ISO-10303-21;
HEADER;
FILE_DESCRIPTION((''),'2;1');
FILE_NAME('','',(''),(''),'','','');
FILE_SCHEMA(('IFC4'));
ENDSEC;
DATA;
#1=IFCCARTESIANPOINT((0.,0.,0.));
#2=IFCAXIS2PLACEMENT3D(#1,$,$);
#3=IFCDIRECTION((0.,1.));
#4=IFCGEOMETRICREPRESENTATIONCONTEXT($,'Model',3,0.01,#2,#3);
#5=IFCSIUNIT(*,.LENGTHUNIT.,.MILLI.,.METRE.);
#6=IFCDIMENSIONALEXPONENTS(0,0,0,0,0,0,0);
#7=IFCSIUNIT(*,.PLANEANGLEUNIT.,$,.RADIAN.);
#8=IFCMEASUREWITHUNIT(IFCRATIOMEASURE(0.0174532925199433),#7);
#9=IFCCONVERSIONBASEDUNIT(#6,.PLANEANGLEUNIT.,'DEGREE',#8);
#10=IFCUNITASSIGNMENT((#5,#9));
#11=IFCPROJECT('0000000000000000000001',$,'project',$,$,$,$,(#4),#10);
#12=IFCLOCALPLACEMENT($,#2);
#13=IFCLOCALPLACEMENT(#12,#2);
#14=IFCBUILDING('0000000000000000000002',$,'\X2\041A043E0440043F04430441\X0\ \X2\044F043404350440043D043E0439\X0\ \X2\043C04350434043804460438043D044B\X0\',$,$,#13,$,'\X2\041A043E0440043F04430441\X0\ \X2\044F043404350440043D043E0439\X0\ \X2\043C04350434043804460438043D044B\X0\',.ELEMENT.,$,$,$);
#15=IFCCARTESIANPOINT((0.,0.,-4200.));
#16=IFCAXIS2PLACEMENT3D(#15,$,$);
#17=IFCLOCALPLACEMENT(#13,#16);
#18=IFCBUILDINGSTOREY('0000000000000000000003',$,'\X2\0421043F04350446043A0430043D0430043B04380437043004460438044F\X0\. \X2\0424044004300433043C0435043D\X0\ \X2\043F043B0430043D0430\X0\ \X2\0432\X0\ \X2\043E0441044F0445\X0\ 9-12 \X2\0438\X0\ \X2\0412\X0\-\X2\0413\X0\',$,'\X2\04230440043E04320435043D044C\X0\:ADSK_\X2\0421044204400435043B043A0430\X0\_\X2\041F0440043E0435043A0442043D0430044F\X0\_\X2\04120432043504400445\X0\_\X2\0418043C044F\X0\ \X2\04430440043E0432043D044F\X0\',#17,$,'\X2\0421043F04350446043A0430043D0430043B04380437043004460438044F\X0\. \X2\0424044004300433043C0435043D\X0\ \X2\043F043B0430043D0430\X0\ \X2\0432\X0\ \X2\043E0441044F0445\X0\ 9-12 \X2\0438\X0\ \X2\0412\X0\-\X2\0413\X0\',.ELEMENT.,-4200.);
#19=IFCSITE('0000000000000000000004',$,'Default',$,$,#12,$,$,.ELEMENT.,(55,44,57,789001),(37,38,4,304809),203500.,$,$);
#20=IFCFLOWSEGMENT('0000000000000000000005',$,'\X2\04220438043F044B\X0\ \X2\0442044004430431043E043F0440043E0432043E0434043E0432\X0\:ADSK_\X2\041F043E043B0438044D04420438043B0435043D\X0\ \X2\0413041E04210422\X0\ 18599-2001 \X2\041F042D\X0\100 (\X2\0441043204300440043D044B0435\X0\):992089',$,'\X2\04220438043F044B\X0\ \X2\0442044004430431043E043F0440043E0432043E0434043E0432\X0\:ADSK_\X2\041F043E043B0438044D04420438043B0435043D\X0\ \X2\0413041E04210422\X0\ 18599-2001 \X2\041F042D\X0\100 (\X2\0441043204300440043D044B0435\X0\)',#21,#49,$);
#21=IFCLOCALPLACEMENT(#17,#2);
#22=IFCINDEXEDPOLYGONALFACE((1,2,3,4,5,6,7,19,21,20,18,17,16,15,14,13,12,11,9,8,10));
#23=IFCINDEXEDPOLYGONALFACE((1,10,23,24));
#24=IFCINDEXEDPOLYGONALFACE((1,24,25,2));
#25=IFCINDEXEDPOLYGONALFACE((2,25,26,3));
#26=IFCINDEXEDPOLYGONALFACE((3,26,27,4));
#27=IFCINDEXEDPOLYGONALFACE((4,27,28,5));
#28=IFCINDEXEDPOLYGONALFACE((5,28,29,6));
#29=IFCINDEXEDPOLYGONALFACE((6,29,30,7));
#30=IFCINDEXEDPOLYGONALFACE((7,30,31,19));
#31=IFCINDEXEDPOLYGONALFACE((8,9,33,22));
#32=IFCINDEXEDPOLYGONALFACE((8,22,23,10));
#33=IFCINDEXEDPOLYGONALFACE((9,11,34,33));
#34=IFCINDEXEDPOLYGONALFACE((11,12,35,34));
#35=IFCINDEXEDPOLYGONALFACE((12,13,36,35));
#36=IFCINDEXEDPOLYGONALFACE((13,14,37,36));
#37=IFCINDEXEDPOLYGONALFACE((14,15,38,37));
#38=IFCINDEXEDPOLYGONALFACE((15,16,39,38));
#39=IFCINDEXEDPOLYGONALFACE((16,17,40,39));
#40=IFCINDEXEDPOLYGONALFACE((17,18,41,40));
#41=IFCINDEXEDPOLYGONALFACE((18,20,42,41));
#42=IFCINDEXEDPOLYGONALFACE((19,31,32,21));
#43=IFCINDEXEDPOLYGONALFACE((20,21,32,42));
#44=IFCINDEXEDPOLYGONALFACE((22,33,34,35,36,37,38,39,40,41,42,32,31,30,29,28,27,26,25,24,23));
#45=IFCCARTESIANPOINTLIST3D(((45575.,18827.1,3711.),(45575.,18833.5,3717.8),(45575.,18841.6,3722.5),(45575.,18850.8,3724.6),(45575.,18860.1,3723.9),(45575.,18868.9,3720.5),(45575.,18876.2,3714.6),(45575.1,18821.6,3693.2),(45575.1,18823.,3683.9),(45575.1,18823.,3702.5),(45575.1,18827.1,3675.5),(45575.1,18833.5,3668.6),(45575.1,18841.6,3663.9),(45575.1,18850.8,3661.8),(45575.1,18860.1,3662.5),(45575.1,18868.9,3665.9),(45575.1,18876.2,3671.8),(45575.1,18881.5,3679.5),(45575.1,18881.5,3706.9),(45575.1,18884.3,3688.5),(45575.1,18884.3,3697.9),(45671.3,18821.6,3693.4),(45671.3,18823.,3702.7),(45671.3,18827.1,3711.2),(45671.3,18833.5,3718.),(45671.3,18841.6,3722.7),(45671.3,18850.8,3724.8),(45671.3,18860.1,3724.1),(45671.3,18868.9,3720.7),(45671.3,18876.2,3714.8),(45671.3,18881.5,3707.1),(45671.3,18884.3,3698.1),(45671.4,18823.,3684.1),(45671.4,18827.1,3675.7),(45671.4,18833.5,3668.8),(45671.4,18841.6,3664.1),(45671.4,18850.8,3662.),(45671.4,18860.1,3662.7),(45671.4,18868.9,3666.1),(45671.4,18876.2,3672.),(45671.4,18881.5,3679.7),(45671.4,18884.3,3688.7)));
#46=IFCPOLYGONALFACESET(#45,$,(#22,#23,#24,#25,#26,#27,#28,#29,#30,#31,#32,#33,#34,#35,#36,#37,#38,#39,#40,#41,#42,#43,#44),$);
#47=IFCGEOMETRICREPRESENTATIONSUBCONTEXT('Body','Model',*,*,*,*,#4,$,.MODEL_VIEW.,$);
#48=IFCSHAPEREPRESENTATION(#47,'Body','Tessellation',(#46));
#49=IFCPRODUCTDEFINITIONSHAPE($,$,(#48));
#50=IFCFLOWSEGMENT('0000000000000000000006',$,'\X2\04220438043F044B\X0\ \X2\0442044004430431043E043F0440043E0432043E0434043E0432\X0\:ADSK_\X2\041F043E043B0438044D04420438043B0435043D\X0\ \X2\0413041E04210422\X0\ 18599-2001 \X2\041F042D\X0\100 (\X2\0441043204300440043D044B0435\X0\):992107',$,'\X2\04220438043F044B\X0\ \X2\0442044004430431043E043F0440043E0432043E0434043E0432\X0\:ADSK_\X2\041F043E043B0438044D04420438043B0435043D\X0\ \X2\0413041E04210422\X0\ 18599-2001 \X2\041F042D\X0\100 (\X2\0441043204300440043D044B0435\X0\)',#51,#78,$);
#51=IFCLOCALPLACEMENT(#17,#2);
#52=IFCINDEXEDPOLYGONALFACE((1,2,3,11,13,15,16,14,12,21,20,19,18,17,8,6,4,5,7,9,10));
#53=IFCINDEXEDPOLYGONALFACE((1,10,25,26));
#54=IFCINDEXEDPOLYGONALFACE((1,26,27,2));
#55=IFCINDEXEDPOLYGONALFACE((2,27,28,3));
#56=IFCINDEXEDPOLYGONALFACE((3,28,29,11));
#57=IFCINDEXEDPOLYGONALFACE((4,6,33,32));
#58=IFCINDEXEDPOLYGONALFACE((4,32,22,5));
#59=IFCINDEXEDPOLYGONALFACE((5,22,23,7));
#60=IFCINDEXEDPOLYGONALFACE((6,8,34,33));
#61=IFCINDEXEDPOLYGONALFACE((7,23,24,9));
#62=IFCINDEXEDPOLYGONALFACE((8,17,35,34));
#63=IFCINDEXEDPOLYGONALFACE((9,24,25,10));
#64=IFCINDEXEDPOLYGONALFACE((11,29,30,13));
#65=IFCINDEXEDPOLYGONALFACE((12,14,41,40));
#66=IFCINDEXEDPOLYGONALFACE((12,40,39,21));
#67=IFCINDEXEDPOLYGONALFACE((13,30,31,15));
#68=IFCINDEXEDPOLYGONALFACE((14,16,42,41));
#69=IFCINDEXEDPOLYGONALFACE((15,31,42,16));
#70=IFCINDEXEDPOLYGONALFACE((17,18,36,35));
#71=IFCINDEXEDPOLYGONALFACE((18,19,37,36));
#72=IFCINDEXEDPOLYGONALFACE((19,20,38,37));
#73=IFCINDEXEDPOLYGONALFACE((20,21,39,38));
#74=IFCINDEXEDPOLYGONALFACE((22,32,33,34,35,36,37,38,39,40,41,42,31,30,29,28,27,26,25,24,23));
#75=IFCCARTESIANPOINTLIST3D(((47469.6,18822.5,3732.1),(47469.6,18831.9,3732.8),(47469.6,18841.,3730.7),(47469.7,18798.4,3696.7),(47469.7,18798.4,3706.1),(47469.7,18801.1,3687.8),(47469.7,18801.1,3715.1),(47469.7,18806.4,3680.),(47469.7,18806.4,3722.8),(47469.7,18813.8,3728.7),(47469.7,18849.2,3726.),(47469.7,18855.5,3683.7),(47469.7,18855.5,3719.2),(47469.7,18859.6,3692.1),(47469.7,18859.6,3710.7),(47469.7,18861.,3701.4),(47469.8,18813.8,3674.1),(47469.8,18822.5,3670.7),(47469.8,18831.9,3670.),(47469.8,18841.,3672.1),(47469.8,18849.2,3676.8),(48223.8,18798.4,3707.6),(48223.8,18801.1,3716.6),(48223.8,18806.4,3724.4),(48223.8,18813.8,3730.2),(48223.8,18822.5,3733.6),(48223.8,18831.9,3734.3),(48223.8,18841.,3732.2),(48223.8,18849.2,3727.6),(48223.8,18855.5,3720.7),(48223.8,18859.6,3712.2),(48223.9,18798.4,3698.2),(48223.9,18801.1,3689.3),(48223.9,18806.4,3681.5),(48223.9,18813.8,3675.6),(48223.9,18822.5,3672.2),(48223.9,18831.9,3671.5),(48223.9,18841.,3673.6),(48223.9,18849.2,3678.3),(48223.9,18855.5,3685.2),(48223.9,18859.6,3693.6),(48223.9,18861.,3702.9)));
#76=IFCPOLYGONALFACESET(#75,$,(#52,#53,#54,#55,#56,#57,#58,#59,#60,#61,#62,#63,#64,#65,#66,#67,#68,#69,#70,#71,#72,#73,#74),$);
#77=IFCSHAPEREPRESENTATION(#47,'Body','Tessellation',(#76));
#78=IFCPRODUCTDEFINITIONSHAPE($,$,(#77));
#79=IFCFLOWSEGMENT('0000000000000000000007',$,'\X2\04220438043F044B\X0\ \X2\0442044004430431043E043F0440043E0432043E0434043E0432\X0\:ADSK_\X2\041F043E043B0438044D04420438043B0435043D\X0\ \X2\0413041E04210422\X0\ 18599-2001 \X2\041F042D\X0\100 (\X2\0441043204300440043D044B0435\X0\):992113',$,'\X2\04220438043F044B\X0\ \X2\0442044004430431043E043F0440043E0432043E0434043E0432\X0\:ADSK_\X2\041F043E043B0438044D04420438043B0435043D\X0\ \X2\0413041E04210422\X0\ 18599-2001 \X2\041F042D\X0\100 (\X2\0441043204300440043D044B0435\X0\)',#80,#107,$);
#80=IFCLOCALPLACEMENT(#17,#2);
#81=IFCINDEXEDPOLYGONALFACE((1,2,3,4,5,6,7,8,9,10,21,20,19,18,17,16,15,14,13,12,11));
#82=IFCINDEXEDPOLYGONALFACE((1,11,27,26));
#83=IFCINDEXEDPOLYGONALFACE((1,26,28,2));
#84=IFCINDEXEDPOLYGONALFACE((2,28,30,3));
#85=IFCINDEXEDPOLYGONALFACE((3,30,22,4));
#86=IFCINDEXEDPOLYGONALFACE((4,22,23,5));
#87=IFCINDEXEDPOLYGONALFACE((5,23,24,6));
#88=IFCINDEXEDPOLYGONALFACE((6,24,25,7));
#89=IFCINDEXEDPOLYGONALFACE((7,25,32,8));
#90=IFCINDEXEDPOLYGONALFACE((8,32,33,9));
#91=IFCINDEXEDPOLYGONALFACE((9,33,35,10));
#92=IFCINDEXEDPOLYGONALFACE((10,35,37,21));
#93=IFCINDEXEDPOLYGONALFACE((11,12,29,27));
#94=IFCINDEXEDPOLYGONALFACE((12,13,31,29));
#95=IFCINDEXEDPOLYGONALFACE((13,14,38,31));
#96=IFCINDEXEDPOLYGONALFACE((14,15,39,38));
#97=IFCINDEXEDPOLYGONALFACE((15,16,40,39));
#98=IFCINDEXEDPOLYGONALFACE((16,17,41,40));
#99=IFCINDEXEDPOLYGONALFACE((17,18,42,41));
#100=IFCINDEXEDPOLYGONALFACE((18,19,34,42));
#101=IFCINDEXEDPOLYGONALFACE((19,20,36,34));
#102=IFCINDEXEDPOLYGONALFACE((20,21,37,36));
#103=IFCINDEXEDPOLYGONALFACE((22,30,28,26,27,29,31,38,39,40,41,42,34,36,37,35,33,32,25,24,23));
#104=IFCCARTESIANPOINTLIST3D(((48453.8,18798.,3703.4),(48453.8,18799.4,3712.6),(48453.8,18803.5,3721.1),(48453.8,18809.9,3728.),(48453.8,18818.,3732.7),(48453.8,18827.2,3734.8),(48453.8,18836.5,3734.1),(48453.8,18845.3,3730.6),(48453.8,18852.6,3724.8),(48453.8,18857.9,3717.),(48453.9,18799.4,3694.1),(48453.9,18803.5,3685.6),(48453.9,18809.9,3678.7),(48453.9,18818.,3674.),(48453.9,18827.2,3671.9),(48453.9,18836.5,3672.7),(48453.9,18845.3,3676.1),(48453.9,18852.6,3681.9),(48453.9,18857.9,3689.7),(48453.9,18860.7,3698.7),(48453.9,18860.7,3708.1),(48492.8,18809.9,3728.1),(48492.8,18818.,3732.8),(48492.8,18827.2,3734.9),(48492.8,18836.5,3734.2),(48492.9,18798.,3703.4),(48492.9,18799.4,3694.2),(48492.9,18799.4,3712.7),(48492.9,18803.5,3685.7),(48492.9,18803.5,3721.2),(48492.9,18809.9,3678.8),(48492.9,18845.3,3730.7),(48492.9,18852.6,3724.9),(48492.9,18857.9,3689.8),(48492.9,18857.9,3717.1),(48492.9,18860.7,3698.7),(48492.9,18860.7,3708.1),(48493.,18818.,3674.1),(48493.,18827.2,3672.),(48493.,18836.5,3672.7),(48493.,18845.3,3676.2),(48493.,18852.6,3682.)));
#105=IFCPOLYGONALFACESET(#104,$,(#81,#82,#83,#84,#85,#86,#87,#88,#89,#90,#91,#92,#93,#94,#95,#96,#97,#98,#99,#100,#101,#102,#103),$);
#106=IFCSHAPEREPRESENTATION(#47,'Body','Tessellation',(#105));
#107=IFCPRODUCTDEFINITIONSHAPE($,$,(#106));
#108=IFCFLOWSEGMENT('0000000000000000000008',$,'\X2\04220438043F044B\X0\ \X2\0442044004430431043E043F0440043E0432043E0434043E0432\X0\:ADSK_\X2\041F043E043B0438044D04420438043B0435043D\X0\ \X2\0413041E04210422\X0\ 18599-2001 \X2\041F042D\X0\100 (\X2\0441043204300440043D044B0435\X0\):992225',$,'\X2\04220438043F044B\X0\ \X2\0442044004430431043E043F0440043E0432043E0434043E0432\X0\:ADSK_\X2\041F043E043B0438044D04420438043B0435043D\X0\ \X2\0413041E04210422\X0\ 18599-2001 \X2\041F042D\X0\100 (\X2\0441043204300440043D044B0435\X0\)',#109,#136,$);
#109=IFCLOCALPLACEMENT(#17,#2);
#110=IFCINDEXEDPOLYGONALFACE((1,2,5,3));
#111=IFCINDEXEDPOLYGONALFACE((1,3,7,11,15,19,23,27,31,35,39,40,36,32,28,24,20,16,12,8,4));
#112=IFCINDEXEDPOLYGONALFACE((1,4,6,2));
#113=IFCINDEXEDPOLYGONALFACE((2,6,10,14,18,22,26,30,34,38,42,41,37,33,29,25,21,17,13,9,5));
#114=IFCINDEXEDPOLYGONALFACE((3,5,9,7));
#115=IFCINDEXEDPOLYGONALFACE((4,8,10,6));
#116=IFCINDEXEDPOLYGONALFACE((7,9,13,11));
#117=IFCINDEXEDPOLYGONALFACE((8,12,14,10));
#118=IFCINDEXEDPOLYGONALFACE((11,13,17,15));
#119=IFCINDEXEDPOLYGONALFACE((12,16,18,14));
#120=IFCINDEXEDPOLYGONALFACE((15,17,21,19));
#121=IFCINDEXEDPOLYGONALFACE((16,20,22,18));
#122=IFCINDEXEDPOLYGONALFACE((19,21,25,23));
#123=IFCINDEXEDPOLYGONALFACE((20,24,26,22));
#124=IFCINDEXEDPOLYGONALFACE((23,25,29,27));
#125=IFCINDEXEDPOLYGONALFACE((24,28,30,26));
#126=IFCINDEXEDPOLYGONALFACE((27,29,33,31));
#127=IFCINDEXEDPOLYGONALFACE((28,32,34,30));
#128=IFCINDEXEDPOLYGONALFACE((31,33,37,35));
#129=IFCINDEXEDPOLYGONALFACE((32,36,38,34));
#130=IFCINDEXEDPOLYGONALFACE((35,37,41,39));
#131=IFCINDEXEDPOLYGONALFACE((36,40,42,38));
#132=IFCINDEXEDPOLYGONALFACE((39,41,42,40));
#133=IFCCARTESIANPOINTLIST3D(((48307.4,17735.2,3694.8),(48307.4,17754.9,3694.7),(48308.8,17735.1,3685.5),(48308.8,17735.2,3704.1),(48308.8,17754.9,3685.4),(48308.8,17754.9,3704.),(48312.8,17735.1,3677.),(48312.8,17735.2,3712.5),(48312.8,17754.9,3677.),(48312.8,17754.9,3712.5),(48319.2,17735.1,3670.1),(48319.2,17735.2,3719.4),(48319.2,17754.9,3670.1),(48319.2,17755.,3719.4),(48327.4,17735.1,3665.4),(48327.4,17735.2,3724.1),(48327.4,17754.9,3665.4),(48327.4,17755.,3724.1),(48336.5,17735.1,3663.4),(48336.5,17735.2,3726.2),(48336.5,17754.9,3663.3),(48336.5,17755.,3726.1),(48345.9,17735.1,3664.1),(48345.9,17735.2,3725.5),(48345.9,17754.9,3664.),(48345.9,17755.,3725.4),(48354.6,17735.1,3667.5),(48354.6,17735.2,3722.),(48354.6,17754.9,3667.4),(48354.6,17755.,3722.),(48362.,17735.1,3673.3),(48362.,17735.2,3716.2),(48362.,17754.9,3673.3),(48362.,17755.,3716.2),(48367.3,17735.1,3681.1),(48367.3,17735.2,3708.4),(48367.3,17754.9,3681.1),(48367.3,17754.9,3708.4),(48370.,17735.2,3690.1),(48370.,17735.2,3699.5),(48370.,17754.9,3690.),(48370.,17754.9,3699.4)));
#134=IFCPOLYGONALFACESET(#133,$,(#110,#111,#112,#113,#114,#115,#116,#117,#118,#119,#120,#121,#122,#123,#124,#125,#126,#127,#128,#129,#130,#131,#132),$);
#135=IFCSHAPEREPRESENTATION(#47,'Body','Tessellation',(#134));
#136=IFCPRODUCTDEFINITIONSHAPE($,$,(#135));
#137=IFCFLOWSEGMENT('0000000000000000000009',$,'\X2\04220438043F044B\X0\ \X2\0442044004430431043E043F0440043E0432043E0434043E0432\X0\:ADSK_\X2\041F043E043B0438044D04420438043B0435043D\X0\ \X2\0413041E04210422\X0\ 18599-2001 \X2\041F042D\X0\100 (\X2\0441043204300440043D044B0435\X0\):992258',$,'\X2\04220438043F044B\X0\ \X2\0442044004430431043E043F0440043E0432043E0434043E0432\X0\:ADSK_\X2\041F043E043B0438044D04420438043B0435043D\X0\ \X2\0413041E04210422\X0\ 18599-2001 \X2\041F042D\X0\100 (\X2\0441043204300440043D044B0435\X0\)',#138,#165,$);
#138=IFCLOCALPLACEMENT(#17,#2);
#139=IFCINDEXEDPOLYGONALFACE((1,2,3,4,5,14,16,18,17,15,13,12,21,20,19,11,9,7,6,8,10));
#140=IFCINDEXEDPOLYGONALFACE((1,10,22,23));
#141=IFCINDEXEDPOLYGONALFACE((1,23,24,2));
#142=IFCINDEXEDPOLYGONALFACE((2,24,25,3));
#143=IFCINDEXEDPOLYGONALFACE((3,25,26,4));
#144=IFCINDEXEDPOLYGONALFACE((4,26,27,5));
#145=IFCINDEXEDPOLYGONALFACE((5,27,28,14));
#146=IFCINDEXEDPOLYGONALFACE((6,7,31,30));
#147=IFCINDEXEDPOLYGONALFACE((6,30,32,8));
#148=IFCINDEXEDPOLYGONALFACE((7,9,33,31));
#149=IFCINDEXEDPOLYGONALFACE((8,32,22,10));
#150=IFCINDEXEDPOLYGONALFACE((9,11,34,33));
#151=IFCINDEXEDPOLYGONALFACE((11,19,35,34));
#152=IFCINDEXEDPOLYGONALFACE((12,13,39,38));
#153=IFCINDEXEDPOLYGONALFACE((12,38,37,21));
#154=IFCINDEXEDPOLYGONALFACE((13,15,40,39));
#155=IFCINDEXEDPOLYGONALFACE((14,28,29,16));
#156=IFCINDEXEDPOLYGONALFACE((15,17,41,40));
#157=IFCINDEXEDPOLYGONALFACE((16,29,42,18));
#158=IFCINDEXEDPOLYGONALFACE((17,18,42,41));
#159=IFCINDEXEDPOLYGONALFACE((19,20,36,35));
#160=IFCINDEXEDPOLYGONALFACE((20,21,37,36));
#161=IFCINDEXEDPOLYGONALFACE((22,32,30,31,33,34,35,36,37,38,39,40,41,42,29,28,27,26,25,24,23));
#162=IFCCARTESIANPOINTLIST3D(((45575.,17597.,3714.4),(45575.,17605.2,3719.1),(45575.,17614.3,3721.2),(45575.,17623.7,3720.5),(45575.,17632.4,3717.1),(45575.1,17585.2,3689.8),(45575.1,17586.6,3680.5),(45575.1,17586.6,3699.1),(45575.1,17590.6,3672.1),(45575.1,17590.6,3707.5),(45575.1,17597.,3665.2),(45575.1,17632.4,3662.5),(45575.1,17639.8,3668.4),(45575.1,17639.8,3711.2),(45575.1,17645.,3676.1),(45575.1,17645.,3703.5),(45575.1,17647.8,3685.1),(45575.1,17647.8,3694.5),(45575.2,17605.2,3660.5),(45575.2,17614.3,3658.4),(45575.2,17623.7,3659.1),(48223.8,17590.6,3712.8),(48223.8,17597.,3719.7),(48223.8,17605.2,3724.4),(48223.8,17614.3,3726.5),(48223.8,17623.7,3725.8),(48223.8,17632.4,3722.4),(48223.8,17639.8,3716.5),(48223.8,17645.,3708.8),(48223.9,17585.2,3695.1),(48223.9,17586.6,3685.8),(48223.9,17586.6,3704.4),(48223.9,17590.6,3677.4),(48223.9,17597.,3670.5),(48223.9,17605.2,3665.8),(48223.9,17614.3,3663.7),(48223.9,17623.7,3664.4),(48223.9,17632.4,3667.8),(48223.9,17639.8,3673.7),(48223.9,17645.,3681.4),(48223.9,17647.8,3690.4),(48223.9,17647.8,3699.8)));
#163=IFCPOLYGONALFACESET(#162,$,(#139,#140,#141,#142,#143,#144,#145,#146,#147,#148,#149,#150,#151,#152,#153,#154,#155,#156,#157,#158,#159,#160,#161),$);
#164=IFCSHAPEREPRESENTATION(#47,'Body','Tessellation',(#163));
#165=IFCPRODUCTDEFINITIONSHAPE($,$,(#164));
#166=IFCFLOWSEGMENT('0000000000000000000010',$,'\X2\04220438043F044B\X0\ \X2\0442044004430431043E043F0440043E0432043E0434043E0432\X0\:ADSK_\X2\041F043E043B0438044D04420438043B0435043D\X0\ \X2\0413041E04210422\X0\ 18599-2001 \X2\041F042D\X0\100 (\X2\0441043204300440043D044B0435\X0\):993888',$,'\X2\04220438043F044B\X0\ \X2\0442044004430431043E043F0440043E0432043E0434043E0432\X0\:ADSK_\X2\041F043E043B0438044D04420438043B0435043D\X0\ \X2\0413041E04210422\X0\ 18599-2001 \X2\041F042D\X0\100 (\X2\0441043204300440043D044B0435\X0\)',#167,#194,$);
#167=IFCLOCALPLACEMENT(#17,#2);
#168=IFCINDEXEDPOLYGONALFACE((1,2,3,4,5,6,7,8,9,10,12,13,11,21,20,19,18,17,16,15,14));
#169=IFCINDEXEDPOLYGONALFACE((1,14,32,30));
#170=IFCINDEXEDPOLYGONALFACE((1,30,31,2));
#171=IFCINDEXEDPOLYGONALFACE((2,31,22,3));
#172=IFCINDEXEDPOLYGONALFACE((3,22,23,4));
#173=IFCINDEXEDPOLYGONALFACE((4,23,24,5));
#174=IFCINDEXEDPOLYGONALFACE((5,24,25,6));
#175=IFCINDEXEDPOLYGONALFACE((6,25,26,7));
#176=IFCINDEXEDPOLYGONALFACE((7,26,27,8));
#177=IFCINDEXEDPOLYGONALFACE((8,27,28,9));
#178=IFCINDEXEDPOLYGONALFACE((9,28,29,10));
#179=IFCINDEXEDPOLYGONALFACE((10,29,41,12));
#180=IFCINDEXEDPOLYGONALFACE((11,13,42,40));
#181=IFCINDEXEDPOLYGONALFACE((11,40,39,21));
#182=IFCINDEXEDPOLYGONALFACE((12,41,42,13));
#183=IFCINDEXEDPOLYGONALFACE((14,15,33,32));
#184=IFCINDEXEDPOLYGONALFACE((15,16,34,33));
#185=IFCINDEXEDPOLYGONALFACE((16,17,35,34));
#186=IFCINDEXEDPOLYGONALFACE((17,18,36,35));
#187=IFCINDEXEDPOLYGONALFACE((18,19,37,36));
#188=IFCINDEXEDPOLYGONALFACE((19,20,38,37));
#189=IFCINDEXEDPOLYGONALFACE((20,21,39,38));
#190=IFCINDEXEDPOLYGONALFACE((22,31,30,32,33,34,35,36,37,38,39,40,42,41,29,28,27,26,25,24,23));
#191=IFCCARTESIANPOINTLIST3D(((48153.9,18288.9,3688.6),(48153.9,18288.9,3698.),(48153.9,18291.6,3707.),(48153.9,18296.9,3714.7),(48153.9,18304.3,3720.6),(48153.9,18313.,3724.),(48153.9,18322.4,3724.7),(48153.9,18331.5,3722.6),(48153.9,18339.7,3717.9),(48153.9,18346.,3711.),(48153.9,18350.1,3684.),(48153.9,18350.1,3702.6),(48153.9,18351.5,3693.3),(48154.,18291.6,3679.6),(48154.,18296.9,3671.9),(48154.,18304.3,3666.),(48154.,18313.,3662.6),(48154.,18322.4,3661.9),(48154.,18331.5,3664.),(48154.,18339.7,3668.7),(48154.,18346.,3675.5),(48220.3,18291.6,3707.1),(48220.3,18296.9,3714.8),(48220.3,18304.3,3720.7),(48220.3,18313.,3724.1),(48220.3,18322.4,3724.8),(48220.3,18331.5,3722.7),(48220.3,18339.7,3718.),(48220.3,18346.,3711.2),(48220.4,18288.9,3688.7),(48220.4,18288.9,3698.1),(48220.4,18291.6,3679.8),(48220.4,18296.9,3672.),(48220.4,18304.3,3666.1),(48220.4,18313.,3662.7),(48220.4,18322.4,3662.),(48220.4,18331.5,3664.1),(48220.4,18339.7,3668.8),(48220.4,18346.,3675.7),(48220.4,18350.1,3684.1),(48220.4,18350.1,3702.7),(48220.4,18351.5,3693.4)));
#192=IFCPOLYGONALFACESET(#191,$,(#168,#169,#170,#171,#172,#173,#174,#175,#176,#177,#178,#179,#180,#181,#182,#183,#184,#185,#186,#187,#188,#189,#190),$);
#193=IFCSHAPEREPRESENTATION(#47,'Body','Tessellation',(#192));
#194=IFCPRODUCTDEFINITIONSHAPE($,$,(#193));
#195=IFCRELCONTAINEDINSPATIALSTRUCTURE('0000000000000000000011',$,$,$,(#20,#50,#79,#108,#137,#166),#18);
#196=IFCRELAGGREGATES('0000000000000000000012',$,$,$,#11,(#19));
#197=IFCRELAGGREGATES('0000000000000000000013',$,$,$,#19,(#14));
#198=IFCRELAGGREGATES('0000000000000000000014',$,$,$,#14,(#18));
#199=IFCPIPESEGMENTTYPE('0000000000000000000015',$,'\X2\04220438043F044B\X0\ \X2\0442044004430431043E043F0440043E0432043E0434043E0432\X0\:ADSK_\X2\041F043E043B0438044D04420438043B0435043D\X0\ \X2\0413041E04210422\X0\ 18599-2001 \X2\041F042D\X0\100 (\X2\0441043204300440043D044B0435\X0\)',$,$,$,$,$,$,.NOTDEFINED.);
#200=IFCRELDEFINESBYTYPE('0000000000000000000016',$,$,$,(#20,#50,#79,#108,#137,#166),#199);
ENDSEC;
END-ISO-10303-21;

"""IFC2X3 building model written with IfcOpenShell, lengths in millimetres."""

from ifc_helpers import new_model, entity, si_unit, converted_unit, direction, frame, frame_2d, origin, origin_2d_with_axis, place, context, subcontext, project, spatial, circle, extrude, type_object, element, save


model = new_model("IFC2X3")

# Units and contexts
model_context = context("Model", 3, precision=0.01, world=origin(), true_north=direction((0.0, 1.0)))
body_context = subcontext(model_context, "Body", "Model", "MODEL_VIEW")
ifc_project = project(units=[si_unit("LENGTHUNIT", "METRE", prefix="MILLI"), converted_unit("PLANEANGLEUNIT", "DEGREE", entity("IfcRatioMeasure", 0.0174532925199433), si_unit("PLANEANGLEUNIT", "RADIAN"), dimensions=[0, 0, 0, 0, 0, 0, 0])], contexts=[model_context])

# Site, building, storey
site_placement = place(None, frame((0.0, 0.0, 0.0)))
site = spatial("IfcSite", under=ifc_project, at=site_placement, Name="Default", CompositionType="ELEMENT", RefLatitude=(55, 44, 57, 789001), RefLongitude=(37, 38, 4, 304809), RefElevation=203500.0)
building_placement = place(site_placement, origin())
building = spatial("IfcBuilding", under=site, at=building_placement, Name="Корпус ядерной медицины", LongName="Корпус ядерной медицины", CompositionType="ELEMENT")
storey_placement = place(building_placement, frame((0.0, 0.0, -4200.0)))
storey = spatial("IfcBuildingStorey", under=building, at=storey_placement, Name="Спецканализация. Фрагмен плана в осях 9-12 и В-Г", ObjectType="Уровень:ADSK_Стрелка_Проектная_Вверх_Имя уровня", LongName="Спецканализация. Фрагмен плана в осях 9-12 и В-Г", CompositionType="ELEMENT", Elevation=-4200.0)

# Flow segments
pipe_segment_type = type_object("IfcPipeSegmentType", Name="Типы трубопроводов:ADSK_Полиэтилен ГОСТ 18599-2001 ПЭ100 (сварные)", PredefinedType="NOTDEFINED")
flow_segment_1_placement = place(storey_placement, frame((45575.0, 18820.0, 3660.1)))
element("IfcFlowSegment", 1, at=flow_segment_1_placement, inside=storey, type_object=pipe_segment_type, Name="Типы трубопроводов:ADSK_Полиэтилен ГОСТ 18599-2001 ПЭ100 (сварные):992089", ObjectType="Типы трубопроводов:ADSK_Полиэтилен ГОСТ 18599-2001 ПЭ100 (сварные)", context=body_context, shape_type="SweptSolid", body=[
    extrude(circle(Radius=31.5, at=origin_2d_with_axis()), frame((0.1, 33.1, 33.1), z_axis=(0.999998, 0.000004, 0.002014), x_axis=(0.000004, -1.0, 0.0)), (0.0, 0.0, 1.0), 96.3),
])
flow_segment_2_placement = place(storey_placement, frame((47469.6, 18796.4, 3668.3)))
element("IfcFlowSegment", 2, at=flow_segment_2_placement, inside=storey, type_object=pipe_segment_type, Name="Типы трубопроводов:ADSK_Полиэтилен ГОСТ 18599-2001 ПЭ100 (сварные):992107", ObjectType="Типы трубопроводов:ADSK_Полиэтилен ГОСТ 18599-2001 ПЭ100 (сварные)", context=body_context, shape_type="SweptSolid", body=[
    extrude(circle(Radius=31.5, at=frame_2d((0.0, 0.0), x_axis=(1.0, 0.0))), frame((0.1, 33.1, 33.1), z_axis=(0.999998, 0.0, 0.001997), x_axis=(0.0, 1.0, 0.0)), (0.0, 0.0, 1.0), 754.2),
])
flow_segment_3_placement = place(storey_placement, frame((48453.8, 18796.4, 3670.3)))
element("IfcFlowSegment", 3, at=flow_segment_3_placement, inside=storey, type_object=pipe_segment_type, Name="Типы трубопроводов:ADSK_Полиэтилен ГОСТ 18599-2001 ПЭ100 (сварные):992113", ObjectType="Типы трубопроводов:ADSK_Полиэтилен ГОСТ 18599-2001 ПЭ100 (сварные)", context=body_context, shape_type="SweptSolid", body=[
    extrude(circle(Radius=31.5, at=frame_2d((0.0, 0.0), x_axis=(1.0, 0.0))), frame((0.1, 33.1, 33.1), z_axis=(0.999998, -0.000211, 0.002038), x_axis=(-0.000211, -1.0, 0.0)), (0.0, 0.0, 1.0), 39.0),
])
flow_segment_4_placement = place(storey_placement, frame((48305.8, 17735.1, 3661.6)))
element("IfcFlowSegment", 4, at=flow_segment_4_placement, inside=storey, type_object=pipe_segment_type, Name="Типы трубопроводов:ADSK_Полиэтилен ГОСТ 18599-2001 ПЭ100 (сварные):992225", ObjectType="Типы трубопроводов:ADSK_Полиэтилен ГОСТ 18599-2001 ПЭ100 (сварные)", context=body_context, shape_type="SweptSolid", body=[
    extrude(circle(Radius=31.5, at=frame_2d((0.0, 0.0), x_axis=(1.0, 0.0))), frame((33.1, 19.8, 33.1), z_axis=(-0.000004, -0.999998, 0.001928), x_axis=(-1.0, 0.000004, 0.0)), (0.0, 0.0, 1.0), 19.8),
])
flow_segment_5_placement = place(storey_placement, frame((45575.0, 17583.6, 3656.7)))
element("IfcFlowSegment", 5, at=flow_segment_5_placement, inside=storey, type_object=pipe_segment_type, Name="Типы трубопроводов:ADSK_Полиэтилен ГОСТ 18599-2001 ПЭ100 (сварные):992258", ObjectType="Типы трубопроводов:ADSK_Полиэтилен ГОСТ 18599-2001 ПЭ100 (сварные)", context=body_context, shape_type="SweptSolid", body=[
    extrude(circle(Radius=31.5, at=frame_2d((0.0, 0.0), x_axis=(1.0, 0.0))), frame((0.1, 33.1, 33.1), z_axis=(0.999998, 0.0, 0.002), x_axis=(0.0, -1.0, 0.0)), (0.0, 0.0, 1.0), 2648.8),
])
flow_segment_6_placement = place(storey_placement, frame((48153.9, 18286.9, 3660.2)))
element("IfcFlowSegment", 6, at=flow_segment_6_placement, inside=storey, type_object=pipe_segment_type, Name="Типы трубопроводов:ADSK_Полиэтилен ГОСТ 18599-2001 ПЭ100 (сварные):993888", ObjectType="Типы трубопроводов:ADSK_Полиэтилен ГОСТ 18599-2001 ПЭ100 (сварные)", context=body_context, shape_type="SweptSolid", body=[
    extrude(circle(Radius=31.5, at=origin_2d_with_axis()), frame((0.1, 33.1, 33.1), z_axis=(0.999998, 0.000004, 0.002), x_axis=(-0.000004, 1.0, 0.0)), (0.0, 0.0, 1.0), 66.4),
])

save(model, "model.ifc")
